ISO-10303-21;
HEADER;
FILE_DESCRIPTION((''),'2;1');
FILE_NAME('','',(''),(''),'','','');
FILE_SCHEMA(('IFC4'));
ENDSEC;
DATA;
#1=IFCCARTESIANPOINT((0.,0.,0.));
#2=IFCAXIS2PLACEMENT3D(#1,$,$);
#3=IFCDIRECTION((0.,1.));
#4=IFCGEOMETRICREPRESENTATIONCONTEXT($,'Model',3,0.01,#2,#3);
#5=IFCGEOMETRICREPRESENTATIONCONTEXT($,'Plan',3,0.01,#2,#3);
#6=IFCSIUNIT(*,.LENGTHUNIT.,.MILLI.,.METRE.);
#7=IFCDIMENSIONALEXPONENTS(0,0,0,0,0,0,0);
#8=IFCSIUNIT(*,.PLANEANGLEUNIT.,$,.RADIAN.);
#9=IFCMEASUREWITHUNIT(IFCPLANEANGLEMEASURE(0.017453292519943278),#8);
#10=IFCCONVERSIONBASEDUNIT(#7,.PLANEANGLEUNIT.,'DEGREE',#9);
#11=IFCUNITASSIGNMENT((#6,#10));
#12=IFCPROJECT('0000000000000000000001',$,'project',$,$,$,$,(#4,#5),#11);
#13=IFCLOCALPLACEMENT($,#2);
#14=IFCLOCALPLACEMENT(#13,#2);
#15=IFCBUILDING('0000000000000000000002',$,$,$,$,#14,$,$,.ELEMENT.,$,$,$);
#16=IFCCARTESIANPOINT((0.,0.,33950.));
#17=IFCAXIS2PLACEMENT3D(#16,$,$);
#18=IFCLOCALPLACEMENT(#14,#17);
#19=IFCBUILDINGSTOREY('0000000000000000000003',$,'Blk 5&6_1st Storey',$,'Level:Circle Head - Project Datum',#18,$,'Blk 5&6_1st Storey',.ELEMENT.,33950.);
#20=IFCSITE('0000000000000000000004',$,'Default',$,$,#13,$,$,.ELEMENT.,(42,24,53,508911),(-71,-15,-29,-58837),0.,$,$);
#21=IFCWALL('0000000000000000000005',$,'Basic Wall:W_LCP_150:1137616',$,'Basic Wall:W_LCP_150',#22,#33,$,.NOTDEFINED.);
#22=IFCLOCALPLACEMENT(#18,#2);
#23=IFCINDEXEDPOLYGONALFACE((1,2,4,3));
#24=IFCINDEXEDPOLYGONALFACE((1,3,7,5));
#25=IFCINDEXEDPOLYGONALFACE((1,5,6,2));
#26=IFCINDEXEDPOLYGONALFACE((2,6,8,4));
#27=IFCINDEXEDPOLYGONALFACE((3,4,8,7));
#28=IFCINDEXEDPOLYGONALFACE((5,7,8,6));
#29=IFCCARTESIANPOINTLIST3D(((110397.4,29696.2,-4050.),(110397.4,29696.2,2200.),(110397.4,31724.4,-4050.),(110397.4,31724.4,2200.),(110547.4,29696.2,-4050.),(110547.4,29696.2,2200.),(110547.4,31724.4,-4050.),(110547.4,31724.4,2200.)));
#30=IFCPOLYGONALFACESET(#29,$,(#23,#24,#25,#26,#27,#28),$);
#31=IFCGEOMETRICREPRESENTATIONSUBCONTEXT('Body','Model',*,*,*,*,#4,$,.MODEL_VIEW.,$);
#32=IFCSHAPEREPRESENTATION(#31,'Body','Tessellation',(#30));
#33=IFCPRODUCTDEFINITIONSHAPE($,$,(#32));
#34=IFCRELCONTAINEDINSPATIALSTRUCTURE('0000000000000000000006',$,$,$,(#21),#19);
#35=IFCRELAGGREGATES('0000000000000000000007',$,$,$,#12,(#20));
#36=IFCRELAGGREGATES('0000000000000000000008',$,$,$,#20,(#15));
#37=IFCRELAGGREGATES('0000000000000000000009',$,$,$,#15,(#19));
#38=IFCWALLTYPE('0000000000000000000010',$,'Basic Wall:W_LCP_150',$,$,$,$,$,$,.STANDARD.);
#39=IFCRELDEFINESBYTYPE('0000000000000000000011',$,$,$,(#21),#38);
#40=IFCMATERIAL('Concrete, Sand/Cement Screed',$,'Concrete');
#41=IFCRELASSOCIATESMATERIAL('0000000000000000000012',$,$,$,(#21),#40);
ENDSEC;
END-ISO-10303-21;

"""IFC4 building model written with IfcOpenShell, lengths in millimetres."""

from ifc_helpers import new_model, entity, si_unit, converted_unit, direction, frame, origin, place, context, subcontext, project, spatial, indexed_curve, outline, extrude, material, type_object, element, save


model = new_model("IFC4")

# Units and contexts
model_context = context("Model", 3, precision=0.01, world=origin(), true_north=direction((0.0, 1.0)))
plan_context = context("Plan", 3, precision=0.01, world=origin(), true_north=direction((0.0, 1.0)))
body_context = subcontext(model_context, "Body", "Model", "MODEL_VIEW")
ifc_project = project(units=[si_unit("LENGTHUNIT", "METRE", prefix="MILLI"), converted_unit("PLANEANGLEUNIT", "DEGREE", entity("IfcPlaneAngleMeasure", 0.017453292519943278), si_unit("PLANEANGLEUNIT", "RADIAN"), dimensions=[0, 0, 0, 0, 0, 0, 0])], contexts=[model_context, plan_context])

# Site, building, storey
site_placement = place(None, origin())
site = spatial("IfcSite", under=ifc_project, at=site_placement, Name="Default", CompositionType="ELEMENT", RefLatitude=(42, 24, 53, 508911), RefLongitude=(-71, -15, -29, -58837), RefElevation=0.0)
building_placement = place(site_placement, origin())
building = spatial("IfcBuilding", under=site, at=building_placement, CompositionType="ELEMENT")
storey_placement = place(building_placement, frame((0.0, 0.0, 33950.0)))
storey = spatial("IfcBuildingStorey", under=building, at=storey_placement, Name="Blk 5&6_1st Storey", ObjectType="Level:Circle Head - Project Datum", LongName="Blk 5&6_1st Storey", CompositionType="ELEMENT", Elevation=33950.0)

# Wall
ifc_material_1 = material(Name="Concrete, Sand/Cement Screed", Category="Concrete")
wall_type_1 = type_object("IfcWallType", Name="Basic Wall:W_LCP_150", PredefinedType="STANDARD")
wall_1_placement = place(storey_placement, frame((110472.4, 29696.2, -4050.0), z_axis=(0.0, 0.0, 1.0), x_axis=(0.0, 1.0, 0.0)))
element("IfcWall", 1, at=wall_1_placement, inside=storey, type_object=wall_type_1, material=ifc_material_1, Name="Basic Wall:W_LCP_150:1137616", ObjectType="Basic Wall:W_LCP_150", PredefinedType="NOTDEFINED", context=body_context, shape_type="SweptSolid", body=[
    extrude(outline(indexed_curve([(2028.1, 75.0), (0.0, 75.0), (0.0, -75.0), (2028.1, -75.0), (2028.1, 75.0)], self_intersect=False)), origin(), (0.0, 0.0, 1.0), 6250.0),
])

save(model, "model.ifc")
